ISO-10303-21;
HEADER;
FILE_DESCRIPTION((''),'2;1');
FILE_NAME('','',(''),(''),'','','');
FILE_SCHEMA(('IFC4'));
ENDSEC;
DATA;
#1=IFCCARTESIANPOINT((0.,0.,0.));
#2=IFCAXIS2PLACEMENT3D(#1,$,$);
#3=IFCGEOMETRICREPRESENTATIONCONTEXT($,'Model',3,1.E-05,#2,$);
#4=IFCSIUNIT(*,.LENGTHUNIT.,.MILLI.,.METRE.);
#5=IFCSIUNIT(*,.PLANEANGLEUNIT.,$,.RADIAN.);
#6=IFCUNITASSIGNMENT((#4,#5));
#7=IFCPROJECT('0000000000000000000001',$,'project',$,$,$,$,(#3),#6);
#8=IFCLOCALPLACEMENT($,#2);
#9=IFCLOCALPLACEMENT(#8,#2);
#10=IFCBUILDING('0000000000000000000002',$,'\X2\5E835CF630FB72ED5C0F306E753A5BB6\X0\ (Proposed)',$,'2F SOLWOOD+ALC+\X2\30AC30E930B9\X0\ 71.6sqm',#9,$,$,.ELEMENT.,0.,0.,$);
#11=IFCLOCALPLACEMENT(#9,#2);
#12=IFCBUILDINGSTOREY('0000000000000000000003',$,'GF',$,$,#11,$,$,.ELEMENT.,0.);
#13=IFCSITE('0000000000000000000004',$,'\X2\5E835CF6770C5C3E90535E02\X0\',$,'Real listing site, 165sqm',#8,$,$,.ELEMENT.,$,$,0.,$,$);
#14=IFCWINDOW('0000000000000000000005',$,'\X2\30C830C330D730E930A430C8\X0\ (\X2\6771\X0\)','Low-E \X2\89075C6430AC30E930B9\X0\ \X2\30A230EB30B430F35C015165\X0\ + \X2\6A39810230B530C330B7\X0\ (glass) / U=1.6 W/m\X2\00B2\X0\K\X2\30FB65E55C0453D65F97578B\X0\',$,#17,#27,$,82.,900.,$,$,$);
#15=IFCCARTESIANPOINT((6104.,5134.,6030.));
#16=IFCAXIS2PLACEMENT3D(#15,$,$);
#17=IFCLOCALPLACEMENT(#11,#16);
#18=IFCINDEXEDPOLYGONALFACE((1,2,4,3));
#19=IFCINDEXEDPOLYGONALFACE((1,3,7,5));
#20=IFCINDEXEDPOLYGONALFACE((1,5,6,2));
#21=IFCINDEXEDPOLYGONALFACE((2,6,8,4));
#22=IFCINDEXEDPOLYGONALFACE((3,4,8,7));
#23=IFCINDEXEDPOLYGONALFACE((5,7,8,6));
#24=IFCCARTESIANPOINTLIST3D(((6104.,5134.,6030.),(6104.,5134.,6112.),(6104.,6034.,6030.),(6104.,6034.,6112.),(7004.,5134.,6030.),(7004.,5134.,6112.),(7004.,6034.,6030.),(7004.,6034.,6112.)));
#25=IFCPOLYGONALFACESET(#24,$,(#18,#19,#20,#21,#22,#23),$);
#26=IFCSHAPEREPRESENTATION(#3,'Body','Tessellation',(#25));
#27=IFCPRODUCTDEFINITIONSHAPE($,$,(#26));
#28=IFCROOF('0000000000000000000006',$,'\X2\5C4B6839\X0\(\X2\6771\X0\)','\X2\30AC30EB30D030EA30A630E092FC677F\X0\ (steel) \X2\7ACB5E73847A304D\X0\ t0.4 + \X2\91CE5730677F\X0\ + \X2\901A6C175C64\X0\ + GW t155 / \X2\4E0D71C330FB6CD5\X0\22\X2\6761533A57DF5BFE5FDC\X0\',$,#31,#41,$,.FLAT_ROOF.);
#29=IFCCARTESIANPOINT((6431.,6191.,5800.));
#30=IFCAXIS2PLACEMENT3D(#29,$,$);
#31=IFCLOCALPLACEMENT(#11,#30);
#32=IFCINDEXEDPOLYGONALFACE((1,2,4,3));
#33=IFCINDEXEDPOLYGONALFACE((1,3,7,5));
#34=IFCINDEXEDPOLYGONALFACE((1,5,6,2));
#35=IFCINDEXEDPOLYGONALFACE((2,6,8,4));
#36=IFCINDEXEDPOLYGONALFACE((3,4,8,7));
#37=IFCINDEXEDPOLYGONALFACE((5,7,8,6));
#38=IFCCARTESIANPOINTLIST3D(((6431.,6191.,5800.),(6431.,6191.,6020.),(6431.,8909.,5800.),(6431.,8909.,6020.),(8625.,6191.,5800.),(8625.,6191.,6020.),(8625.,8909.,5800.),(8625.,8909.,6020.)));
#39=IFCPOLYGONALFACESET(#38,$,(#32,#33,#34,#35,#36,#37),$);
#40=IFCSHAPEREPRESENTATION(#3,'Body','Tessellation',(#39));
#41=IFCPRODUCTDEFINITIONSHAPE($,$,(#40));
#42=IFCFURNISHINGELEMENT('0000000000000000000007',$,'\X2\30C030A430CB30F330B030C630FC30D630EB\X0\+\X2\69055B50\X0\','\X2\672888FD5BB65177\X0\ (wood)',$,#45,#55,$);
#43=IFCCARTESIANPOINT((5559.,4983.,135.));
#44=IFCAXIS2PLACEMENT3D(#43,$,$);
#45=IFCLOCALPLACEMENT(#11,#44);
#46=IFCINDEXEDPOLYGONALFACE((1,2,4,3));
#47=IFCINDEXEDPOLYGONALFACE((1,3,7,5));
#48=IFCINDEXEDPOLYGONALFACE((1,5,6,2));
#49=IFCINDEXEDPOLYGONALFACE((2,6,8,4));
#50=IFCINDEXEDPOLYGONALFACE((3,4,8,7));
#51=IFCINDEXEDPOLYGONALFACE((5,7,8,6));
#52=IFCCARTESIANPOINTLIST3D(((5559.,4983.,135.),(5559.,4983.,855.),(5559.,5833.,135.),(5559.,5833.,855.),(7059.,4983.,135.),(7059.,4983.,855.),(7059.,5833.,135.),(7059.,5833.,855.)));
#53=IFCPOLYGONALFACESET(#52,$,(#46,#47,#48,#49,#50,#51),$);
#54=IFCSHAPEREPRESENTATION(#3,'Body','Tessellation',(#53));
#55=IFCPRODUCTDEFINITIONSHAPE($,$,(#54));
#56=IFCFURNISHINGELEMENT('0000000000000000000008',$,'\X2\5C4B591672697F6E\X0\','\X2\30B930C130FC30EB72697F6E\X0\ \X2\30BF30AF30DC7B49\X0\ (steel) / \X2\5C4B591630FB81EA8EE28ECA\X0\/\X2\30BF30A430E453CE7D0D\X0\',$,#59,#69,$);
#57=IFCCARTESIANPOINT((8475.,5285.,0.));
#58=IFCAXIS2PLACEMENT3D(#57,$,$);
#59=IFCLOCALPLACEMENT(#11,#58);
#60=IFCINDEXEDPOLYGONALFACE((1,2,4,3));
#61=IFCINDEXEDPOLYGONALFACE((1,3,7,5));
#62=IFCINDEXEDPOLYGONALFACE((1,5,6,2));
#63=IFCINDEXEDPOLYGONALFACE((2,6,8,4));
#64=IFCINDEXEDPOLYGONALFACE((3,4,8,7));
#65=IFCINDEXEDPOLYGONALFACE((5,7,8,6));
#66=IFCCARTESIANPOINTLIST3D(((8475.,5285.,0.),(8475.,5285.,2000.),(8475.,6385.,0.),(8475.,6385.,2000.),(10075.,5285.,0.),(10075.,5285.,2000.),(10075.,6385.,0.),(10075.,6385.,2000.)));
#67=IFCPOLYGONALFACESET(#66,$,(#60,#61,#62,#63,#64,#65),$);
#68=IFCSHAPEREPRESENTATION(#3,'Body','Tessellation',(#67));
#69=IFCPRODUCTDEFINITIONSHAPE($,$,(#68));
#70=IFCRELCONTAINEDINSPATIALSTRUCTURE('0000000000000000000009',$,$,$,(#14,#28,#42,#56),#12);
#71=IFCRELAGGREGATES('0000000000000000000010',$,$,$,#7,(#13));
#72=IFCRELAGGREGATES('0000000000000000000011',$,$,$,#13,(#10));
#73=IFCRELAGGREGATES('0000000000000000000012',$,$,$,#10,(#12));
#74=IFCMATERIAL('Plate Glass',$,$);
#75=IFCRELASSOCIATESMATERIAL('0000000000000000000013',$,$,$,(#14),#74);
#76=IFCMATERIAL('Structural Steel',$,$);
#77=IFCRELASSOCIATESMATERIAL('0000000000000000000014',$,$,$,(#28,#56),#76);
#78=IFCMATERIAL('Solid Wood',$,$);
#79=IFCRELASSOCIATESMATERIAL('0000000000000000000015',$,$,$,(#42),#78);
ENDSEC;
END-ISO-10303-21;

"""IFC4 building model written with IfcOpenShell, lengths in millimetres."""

from ifc_helpers import new_model, si_unit, frame, frame_2d, origin, place, context, project, spatial, rectangle, extrude, material, element, save


model = new_model("IFC4")

# Units and contexts
model_context = context("Model", 3, precision=1e-05, world=origin())
ifc_project = project(units=[si_unit("LENGTHUNIT", "METRE", prefix="MILLI"), si_unit("PLANEANGLEUNIT", "RADIAN")], contexts=[model_context])

# Site, building, storey
site_placement = place(None, origin())
site = spatial("IfcSite", under=ifc_project, at=site_placement, Name="広島県尾道市", ObjectType="Real listing site, 165sqm", CompositionType="ELEMENT", RefElevation=0.0)
building_placement = place(site_placement, origin())
building = spatial("IfcBuilding", under=site, at=building_placement, Name="広島・狭小の町家 (Proposed)", ObjectType="2F SOLWOOD+ALC+ガラス 71.6sqm", CompositionType="ELEMENT", ElevationOfRefHeight=0.0, ElevationOfTerrain=0.0)
storey_placement = place(building_placement, origin())
storey = spatial("IfcBuildingStorey", under=building, at=storey_placement, Name="GF", CompositionType="ELEMENT", Elevation=0.0)

# Shared definitions
ifc_material_1 = material(Name="Solid Wood")

# Shared definitions
ifc_material_2 = material(Name="Plate Glass")

# Window
window_1_placement = place(storey_placement, frame((6104.0, 5134.0, 6030.0)))
element("IfcWindow", 1, at=window_1_placement, inside=storey, material=ifc_material_2, Name="トップライト (東)", Description="Low-E 複層ガラス アルゴン封入 + 樹脂サッシ (glass) / U=1.6 W/m²K・日射取得型", OverallHeight=82.0, OverallWidth=900.0, context=model_context, shape_type="SweptSolid", body=[
    extrude(rectangle(XDim=900.0, YDim=900.0, at=frame_2d((450.0, 450.0))), frame((6104.0, 5134.0, 6030.0)), (0.0, 0.0, 1.0), 82.0),
])

# Roof
ifc_material_3 = material(Name="Structural Steel")
for number, where, name in (
    (2, (6431.0, 6191.0, 5800.0), "屋根(東)"),
):
    element("IfcRoof", number, at=place(storey_placement, frame(where)), inside=storey, material=ifc_material_3, Name=name, Description="ガルバリウム鋼板 (steel) 立平葺き t0.4 + 野地板 + 通気層 + GW t155 / 不燃・法22条区域対応", PredefinedType="FLAT_ROOF", context=model_context, shape_type="SweptSolid", body=[
        extrude(rectangle(XDim=2194.0, YDim=2718.0, at=frame_2d((1097.0, 1359.0))), frame((6431.0, 6191.0, 5800.0)), (0.0, 0.0, 1.0), 220.0),
    ])

# Furnishing elements
furnishing_1_placement = place(storey_placement, frame((5559.0, 4983.0, 135.0)))
element("IfcFurnishingElement", 3, at=furnishing_1_placement, inside=storey, material=ifc_material_1, Name="ダイニングテーブル+椅子", Description="木製家具 (wood)", context=model_context, shape_type="SweptSolid", body=[
    extrude(rectangle(XDim=1500.0, YDim=850.0, at=frame_2d((750.0, 425.0))), frame((5559.0, 4983.0, 135.0)), (0.0, 0.0, 1.0), 720.0),
])
furnishing_2_placement = place(storey_placement, frame((8475.0, 5285.0, 0.0)))
element("IfcFurnishingElement", 4, at=furnishing_2_placement, inside=storey, material=ifc_material_3, Name="屋外物置", Description="スチール物置 タクボ等 (steel) / 屋外・自転車/タイヤ収納", context=model_context, shape_type="SweptSolid", body=[
    extrude(rectangle(XDim=1600.0, YDim=1100.0, at=frame_2d((800.0, 550.0))), frame((8475.0, 5285.0, 0.0)), (0.0, 0.0, 1.0), 2000.0),
])

save(model, "model.ifc")
